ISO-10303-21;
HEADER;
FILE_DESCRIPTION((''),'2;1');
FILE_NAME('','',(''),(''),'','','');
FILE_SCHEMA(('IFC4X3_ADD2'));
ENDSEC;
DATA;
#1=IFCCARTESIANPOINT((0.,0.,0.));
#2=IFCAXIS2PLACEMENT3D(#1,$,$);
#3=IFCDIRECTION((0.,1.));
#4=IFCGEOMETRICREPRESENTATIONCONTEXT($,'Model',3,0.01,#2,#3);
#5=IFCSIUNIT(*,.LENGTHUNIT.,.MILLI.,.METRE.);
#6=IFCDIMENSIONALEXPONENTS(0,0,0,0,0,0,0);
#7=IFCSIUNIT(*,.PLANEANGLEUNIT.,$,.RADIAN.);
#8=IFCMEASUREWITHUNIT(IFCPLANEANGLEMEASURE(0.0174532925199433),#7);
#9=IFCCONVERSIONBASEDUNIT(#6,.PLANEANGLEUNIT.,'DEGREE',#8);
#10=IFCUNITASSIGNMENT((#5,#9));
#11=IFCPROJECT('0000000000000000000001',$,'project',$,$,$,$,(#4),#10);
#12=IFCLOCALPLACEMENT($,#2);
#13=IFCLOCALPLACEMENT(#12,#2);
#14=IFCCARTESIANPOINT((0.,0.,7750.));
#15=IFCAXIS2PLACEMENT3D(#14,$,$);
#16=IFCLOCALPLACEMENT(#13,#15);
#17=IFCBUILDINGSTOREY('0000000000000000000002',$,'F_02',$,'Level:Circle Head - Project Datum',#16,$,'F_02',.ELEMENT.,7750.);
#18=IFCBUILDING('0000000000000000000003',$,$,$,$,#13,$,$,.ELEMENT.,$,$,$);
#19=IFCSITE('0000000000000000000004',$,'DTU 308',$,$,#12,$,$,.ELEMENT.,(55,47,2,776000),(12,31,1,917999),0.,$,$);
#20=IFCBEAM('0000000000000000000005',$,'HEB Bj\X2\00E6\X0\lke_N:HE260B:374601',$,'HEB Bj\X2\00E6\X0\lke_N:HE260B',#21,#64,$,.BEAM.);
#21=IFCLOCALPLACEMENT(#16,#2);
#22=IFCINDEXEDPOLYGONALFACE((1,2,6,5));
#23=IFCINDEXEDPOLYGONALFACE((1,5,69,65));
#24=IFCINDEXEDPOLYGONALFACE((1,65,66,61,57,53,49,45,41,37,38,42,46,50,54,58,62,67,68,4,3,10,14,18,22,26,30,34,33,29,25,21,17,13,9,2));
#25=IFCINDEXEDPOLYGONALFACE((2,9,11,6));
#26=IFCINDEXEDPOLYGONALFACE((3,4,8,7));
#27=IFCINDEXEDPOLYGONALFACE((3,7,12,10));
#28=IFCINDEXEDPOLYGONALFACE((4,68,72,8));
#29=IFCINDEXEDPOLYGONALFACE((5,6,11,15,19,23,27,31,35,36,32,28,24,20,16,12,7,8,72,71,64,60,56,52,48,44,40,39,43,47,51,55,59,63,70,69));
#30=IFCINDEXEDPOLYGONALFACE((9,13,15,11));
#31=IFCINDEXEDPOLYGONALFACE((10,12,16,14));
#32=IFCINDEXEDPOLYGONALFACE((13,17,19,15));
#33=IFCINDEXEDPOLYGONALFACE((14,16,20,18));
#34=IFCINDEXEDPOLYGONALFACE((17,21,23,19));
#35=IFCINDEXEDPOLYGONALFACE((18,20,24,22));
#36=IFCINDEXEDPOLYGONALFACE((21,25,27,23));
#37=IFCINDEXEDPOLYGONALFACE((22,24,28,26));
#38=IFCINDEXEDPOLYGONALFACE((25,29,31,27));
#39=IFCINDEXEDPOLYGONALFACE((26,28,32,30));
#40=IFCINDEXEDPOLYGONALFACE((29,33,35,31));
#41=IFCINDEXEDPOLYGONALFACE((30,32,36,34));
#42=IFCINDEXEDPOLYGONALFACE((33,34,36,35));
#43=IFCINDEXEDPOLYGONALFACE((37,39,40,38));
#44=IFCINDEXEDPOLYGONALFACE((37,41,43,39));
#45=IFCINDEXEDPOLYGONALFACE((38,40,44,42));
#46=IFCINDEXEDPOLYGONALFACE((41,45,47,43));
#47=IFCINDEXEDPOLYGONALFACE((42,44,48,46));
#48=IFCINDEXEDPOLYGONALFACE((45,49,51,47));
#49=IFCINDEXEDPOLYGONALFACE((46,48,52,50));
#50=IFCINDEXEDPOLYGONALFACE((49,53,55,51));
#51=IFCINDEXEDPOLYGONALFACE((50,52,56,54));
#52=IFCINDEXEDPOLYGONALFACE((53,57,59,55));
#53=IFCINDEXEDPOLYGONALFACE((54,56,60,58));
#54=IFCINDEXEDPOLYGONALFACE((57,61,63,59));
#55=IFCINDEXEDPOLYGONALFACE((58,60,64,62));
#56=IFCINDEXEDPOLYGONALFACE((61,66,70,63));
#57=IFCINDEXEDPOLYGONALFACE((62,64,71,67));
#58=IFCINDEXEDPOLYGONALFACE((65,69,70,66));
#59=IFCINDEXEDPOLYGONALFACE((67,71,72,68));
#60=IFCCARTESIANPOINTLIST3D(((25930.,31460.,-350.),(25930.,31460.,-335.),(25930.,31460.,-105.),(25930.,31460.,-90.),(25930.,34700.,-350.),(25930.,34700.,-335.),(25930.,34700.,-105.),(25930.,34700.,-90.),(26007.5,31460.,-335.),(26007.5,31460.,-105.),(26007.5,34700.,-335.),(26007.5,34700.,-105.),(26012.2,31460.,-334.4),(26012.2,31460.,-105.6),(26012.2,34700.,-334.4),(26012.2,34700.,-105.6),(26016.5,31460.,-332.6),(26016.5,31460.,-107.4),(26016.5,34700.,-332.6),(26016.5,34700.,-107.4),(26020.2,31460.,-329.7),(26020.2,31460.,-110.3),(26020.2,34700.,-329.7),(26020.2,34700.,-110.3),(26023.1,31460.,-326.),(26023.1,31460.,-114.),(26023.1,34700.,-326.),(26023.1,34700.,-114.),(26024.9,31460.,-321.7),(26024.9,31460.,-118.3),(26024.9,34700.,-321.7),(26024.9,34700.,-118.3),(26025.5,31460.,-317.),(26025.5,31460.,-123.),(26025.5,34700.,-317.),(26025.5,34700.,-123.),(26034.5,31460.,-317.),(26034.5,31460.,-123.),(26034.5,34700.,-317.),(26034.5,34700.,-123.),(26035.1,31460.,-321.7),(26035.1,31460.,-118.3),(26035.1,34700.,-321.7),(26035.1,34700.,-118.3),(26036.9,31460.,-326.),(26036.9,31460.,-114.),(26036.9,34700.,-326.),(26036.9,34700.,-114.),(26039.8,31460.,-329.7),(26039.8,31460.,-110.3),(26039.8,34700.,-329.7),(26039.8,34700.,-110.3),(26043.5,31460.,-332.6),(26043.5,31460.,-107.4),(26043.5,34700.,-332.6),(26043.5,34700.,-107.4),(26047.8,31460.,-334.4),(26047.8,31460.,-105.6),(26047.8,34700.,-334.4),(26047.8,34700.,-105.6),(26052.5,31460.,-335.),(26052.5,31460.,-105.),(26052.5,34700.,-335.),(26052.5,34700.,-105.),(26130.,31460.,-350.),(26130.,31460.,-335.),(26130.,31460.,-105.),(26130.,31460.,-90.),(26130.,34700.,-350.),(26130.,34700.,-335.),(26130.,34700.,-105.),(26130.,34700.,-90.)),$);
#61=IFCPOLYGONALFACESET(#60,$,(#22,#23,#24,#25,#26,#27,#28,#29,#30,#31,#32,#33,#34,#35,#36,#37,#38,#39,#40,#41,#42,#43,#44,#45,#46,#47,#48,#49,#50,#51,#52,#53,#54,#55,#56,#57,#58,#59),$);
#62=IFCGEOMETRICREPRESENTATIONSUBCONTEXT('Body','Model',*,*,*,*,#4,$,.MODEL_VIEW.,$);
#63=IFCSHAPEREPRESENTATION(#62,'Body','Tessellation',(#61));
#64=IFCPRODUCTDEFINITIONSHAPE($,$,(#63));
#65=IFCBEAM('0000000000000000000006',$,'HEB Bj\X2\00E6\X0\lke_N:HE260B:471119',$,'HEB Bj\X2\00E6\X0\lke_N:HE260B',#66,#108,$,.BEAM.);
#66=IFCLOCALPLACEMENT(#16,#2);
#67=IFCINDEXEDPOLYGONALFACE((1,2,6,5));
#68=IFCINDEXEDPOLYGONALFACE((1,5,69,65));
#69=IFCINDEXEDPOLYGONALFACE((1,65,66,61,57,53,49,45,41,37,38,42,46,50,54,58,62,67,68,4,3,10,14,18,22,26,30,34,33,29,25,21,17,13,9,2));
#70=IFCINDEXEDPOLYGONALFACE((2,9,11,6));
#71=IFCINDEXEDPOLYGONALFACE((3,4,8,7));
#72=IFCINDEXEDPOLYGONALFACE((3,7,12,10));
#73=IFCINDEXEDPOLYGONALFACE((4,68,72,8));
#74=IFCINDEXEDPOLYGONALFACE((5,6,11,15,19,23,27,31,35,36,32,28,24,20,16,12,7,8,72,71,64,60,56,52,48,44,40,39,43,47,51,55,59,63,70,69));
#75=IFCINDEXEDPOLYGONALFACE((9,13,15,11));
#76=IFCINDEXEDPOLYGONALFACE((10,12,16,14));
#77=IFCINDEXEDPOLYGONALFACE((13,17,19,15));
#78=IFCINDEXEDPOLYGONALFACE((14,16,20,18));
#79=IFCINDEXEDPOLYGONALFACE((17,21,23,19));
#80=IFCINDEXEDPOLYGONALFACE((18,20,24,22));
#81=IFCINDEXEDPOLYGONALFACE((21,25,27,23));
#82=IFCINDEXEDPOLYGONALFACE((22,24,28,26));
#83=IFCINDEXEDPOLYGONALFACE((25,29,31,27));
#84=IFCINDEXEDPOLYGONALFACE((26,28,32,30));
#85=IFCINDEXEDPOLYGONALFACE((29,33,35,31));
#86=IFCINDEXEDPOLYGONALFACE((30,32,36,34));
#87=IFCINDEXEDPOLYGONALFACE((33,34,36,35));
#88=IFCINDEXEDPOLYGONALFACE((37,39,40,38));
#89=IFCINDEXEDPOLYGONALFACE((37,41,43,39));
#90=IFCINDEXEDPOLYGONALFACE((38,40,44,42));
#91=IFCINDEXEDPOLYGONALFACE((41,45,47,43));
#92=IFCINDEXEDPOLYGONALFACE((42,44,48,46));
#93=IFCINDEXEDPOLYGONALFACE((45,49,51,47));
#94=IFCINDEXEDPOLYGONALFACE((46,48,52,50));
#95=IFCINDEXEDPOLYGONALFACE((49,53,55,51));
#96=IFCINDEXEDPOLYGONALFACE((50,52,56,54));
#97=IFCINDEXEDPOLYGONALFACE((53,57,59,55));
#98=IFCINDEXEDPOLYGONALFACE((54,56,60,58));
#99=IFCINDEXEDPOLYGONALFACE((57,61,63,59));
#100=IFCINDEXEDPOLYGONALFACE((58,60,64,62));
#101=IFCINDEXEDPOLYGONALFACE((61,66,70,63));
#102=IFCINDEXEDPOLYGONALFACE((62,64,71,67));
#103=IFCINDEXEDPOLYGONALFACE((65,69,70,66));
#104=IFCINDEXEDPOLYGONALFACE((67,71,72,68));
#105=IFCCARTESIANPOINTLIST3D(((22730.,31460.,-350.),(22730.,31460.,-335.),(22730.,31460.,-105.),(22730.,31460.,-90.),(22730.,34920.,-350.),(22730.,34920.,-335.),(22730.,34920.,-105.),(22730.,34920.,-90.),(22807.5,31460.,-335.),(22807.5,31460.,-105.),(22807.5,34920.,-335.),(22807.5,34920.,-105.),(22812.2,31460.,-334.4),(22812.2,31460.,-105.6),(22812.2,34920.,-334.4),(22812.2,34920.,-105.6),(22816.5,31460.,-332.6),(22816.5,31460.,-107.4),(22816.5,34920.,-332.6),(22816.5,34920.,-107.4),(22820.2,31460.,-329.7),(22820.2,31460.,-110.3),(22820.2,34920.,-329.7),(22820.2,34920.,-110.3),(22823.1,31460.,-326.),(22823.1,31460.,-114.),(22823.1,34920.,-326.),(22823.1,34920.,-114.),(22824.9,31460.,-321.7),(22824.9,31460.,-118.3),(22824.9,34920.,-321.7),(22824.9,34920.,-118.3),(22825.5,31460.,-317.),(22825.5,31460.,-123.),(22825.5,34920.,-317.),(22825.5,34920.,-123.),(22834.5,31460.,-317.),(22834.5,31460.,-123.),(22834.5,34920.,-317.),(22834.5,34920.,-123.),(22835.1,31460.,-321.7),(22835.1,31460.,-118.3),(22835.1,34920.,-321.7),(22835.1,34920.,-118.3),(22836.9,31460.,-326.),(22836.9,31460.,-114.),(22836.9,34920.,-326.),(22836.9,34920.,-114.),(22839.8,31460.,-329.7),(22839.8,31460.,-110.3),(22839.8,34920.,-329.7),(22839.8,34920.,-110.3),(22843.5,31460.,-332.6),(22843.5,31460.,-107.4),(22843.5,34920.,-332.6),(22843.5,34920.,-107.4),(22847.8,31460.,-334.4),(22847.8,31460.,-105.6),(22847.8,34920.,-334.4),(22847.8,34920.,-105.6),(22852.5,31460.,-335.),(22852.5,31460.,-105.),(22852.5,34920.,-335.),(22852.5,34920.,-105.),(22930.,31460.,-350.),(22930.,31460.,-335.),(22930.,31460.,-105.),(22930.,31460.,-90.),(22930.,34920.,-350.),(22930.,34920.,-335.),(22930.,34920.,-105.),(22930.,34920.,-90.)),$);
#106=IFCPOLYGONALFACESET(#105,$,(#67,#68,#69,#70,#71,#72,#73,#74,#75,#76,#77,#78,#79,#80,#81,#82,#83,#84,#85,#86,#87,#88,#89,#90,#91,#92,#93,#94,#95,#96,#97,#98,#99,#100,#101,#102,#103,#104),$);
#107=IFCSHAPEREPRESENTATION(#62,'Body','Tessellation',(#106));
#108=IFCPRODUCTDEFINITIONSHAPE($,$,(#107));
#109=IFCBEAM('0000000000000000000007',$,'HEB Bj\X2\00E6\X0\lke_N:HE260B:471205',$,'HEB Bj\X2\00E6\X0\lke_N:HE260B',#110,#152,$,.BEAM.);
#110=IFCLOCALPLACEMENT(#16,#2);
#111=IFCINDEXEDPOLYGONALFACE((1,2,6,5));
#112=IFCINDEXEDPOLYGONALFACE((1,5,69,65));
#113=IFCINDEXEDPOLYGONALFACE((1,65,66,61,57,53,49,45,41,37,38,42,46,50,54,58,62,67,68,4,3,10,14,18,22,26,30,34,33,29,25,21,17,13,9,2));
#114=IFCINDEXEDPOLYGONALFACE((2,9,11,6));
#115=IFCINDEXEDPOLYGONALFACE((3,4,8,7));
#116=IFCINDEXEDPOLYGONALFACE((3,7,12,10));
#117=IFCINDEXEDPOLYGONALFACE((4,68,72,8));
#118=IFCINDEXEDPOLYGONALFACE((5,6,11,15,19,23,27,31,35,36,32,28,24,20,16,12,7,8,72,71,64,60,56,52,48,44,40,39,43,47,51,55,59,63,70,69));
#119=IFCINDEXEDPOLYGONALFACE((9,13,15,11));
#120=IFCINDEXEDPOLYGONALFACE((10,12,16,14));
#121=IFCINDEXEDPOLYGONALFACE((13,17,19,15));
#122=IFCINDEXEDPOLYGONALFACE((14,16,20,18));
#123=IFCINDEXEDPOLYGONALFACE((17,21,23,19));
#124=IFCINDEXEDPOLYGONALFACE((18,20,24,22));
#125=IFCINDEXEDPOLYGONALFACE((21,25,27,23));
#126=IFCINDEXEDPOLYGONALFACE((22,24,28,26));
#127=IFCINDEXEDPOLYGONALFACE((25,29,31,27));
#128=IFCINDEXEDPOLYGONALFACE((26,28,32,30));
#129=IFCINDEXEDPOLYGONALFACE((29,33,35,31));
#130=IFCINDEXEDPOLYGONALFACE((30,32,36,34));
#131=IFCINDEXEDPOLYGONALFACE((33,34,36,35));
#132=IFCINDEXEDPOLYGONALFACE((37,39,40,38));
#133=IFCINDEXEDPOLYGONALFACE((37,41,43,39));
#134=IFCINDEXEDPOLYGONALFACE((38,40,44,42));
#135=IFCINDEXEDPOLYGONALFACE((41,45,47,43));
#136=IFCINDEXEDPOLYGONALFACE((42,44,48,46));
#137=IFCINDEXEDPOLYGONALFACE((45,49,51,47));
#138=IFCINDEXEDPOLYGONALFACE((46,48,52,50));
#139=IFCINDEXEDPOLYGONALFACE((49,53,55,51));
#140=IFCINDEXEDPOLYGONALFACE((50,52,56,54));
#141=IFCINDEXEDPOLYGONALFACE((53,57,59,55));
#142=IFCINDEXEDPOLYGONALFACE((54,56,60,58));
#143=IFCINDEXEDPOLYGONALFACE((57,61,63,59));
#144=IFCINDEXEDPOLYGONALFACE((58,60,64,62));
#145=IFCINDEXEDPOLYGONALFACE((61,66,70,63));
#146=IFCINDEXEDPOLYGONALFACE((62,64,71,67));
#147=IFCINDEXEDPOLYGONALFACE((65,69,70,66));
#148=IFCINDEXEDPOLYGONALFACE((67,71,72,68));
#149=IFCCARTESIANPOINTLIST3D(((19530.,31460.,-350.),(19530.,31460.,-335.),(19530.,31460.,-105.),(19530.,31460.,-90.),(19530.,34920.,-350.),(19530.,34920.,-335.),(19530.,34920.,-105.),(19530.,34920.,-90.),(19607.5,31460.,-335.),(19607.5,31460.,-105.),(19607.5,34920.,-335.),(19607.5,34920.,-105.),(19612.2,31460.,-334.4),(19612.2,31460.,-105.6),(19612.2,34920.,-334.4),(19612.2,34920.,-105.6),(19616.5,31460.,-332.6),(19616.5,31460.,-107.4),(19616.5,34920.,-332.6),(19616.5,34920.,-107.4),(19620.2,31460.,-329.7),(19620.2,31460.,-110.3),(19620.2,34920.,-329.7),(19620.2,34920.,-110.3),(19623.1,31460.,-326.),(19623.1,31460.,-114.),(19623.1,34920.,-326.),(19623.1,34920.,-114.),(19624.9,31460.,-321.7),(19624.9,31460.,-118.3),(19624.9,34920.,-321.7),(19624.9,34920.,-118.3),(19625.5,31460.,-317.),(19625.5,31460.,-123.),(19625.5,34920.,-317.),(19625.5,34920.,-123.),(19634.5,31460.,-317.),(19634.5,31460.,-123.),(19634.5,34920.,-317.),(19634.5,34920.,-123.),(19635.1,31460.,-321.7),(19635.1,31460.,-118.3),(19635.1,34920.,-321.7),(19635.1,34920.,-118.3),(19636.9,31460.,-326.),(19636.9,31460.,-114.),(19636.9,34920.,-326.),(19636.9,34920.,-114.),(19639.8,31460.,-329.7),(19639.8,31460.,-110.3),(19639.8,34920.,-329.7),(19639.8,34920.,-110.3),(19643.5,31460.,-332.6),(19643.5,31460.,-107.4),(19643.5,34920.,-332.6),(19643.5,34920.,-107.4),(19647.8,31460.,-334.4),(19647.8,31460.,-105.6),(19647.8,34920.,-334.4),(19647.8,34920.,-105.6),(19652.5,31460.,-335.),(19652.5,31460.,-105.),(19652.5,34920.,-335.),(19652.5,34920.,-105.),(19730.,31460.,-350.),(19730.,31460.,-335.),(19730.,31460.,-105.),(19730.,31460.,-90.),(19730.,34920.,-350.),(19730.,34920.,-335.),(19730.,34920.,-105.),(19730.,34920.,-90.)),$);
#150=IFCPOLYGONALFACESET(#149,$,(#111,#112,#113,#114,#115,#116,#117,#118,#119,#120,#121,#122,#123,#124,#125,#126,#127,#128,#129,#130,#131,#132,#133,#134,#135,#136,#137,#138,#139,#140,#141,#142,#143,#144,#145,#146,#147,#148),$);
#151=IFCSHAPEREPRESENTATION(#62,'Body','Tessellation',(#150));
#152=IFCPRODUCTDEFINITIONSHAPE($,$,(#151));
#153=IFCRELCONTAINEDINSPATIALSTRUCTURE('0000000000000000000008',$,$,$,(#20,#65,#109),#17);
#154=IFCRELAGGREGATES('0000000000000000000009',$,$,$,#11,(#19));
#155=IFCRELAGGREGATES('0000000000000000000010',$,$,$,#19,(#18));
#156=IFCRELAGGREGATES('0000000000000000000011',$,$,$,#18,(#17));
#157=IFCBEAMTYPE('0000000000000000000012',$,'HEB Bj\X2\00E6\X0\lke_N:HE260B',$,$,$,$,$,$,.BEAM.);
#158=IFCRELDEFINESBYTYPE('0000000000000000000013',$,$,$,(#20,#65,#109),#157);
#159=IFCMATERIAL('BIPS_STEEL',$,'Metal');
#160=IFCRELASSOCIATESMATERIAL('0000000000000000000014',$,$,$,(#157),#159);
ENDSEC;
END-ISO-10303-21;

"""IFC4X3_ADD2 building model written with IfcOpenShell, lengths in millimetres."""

from ifc_helpers import new_model, entity, si_unit, converted_unit, direction, frame, frame_2d, origin, place, context, subcontext, project, spatial, polyline, circle_curve, parameter, trimmed, segment, composite_curve, i_section, outline, extrude, source, transform, mapped, material, material_profile, profile_set, type_object, element, save


model = new_model("IFC4X3_ADD2")

# Units and contexts
model_context = context("Model", 3, precision=0.01, world=origin(), true_north=direction((0.0, 1.0)))
body_context = subcontext(model_context, "Body", "Model", "MODEL_VIEW")
ifc_project = project(units=[si_unit("LENGTHUNIT", "METRE", prefix="MILLI"), converted_unit("PLANEANGLEUNIT", "DEGREE", entity("IfcPlaneAngleMeasure", 0.0174532925199433), si_unit("PLANEANGLEUNIT", "RADIAN"), dimensions=[0, 0, 0, 0, 0, 0, 0])], contexts=[model_context])

# Site, building, storey
site_placement = place(None, origin())
site = spatial("IfcSite", under=ifc_project, at=site_placement, Name="DTU 308", CompositionType="ELEMENT", RefLatitude=(55, 47, 2, 776000), RefLongitude=(12, 31, 1, 917999), RefElevation=0.0)
building_placement = place(site_placement, origin())
building = spatial("IfcBuilding", under=site, at=building_placement, CompositionType="ELEMENT")
storey_placement = place(building_placement, frame((0.0, 0.0, 7750.0)))
storey = spatial("IfcBuildingStorey", under=building, at=storey_placement, Name="F_02", ObjectType="Level:Circle Head - Project Datum", LongName="F_02", CompositionType="ELEMENT", Elevation=7750.0)

# Shared definitions
ifc_material = material(Name="BIPS_STEEL", Category="Metal")

# Beams
ifc_material_profile_1 = material_profile(ifc_material, i_section(OverallWidth=200.0, OverallDepth=260.0, WebThickness=9.0, FlangeThickness=15.0, FilletRadius=18.0, at=frame_2d((0.0, 0.0), x_axis=(1.0, 0.0))), Name="HE260B")
ifc_profile_set_1 = profile_set([ifc_material_profile_1], Name="HE260B")
beam_type_1 = type_object("IfcBeamType", Name="HEB Bjælke_N:HE260B", PredefinedType="BEAM", material=ifc_profile_set_1)
shared_shape_1 = source(origin(), body_context, "Body", "SweptSolid", [
    extrude(outline(composite_curve([segment(polyline([(-100.0, -115.0), (-100.0, -130.0)]), True, "CONTINUOUS"), segment(polyline([(-100.0, -130.0), (100.0, -130.0)]), True, "CONTINUOUS"), segment(polyline([(100.0, -130.0), (100.0, -115.0)]), True, "CONTINUOUS"), segment(polyline([(100.0, -115.0), (22.5, -115.0)]), True, "CONTINUOUS"), segment(trimmed(circle_curve(frame_2d((22.5, -97.0), x_axis=(1.0, 0.0)), 18.0), [parameter(180.0)], [parameter(270.0)], True, "PARAMETER"), False, "CONTINUOUS"), segment(polyline([(4.5, -97.0), (4.5, 97.0)]), True, "CONTINUOUS"), segment(trimmed(circle_curve(frame_2d((22.5, 97.0), x_axis=(1.0, 0.0)), 18.0), [parameter(90.0)], [parameter(180.0)], True, "PARAMETER"), False, "CONTINUOUS"), segment(polyline([(22.5, 115.0), (100.0, 115.0)]), True, "CONTINUOUS"), segment(polyline([(100.0, 115.0), (100.0, 130.0)]), True, "CONTINUOUS"), segment(polyline([(100.0, 130.0), (-100.0, 130.0)]), True, "CONTINUOUS"), segment(polyline([(-100.0, 130.0), (-100.0, 115.0)]), True, "CONTINUOUS"), segment(polyline([(-100.0, 115.0), (-22.5, 115.0)]), True, "CONTINUOUS"), segment(trimmed(circle_curve(frame_2d((-22.5, 97.0), x_axis=(1.0, 0.0)), 18.0), [parameter(360.0)], [parameter(90.0)], True, "PARAMETER"), False, "CONTINUOUS"), segment(polyline([(-4.5, 97.0), (-4.5, -97.0)]), True, "CONTINUOUS"), segment(trimmed(circle_curve(frame_2d((-22.5, -97.0), x_axis=(1.0, 0.0)), 18.0), [parameter(270.0)], [parameter(360.0)], True, "PARAMETER"), False, "CONTINUOUS"), segment(polyline([(-22.5, -115.0), (-100.0, -115.0)]), True, "CONTINUOUS")], self_intersect=False)), frame((-1500.0, 0.0, 0.0), z_axis=(-1.0, 0.0, 0.0), x_axis=(0.0, -1.0, 0.0)), (0.0, 0.0, -1.0), 3240.0),
])
beam_1_placement = place(storey_placement, frame((26030.0, 33200.0, -220.0), z_axis=(0.0, 0.0, 1.0), x_axis=(0.0, -1.0, 0.0)))
element("IfcBeam", 1, at=beam_1_placement, inside=storey, type_object=beam_type_1, Name="HEB Bjælke_N:HE260B:374601", ObjectType="HEB Bjælke_N:HE260B", PredefinedType="BEAM", context=body_context, shape_type="MappedRepresentation", body=[
    mapped(shared_shape_1, transform((0.0, 0.0, 0.0), scale=1.0)),
])
shared_shape_2 = source(origin(), body_context, "Body", "SweptSolid", [
    extrude(outline(composite_curve([segment(polyline([(-100.0, -115.0), (-100.0, -130.0)]), True, "CONTINUOUS"), segment(polyline([(-100.0, -130.0), (100.0, -130.0)]), True, "CONTINUOUS"), segment(polyline([(100.0, -130.0), (100.0, -115.0)]), True, "CONTINUOUS"), segment(polyline([(100.0, -115.0), (22.5, -115.0)]), True, "CONTINUOUS"), segment(trimmed(circle_curve(frame_2d((22.5, -97.0), x_axis=(1.0, 0.0)), 18.0), [parameter(180.0)], [parameter(270.0)], True, "PARAMETER"), False, "CONTINUOUS"), segment(polyline([(4.5, -97.0), (4.5, 97.0)]), True, "CONTINUOUS"), segment(trimmed(circle_curve(frame_2d((22.5, 97.0), x_axis=(1.0, 0.0)), 18.0), [parameter(90.0)], [parameter(180.0)], True, "PARAMETER"), False, "CONTINUOUS"), segment(polyline([(22.5, 115.0), (100.0, 115.0)]), True, "CONTINUOUS"), segment(polyline([(100.0, 115.0), (100.0, 130.0)]), True, "CONTINUOUS"), segment(polyline([(100.0, 130.0), (-100.0, 130.0)]), True, "CONTINUOUS"), segment(polyline([(-100.0, 130.0), (-100.0, 115.0)]), True, "CONTINUOUS"), segment(polyline([(-100.0, 115.0), (-22.5, 115.0)]), True, "CONTINUOUS"), segment(trimmed(circle_curve(frame_2d((-22.5, 97.0), x_axis=(1.0, 0.0)), 18.0), [parameter(360.0)], [parameter(90.0)], True, "PARAMETER"), False, "CONTINUOUS"), segment(polyline([(-4.5, 97.0), (-4.5, -97.0)]), True, "CONTINUOUS"), segment(trimmed(circle_curve(frame_2d((-22.5, -97.0), x_axis=(1.0, 0.0)), 18.0), [parameter(270.0)], [parameter(360.0)], True, "PARAMETER"), False, "CONTINUOUS"), segment(polyline([(-22.5, -115.0), (-100.0, -115.0)]), True, "CONTINUOUS")], self_intersect=False)), frame((-1720.0, 0.0, 0.0), z_axis=(-1.0, 0.0, 0.0), x_axis=(0.0, -1.0, 0.0)), (0.0, 0.0, -1.0), 3460.0),
])
for number, where, z_axis, x_axis, name in (
    (2, (22830.0, 33200.0, -220.0), (0.0, 0.0, 1.0), (0.0, -1.0, 0.0), "HEB Bjælke_N:HE260B:471119"),
    (3, (19630.0, 33200.0, -220.0), (0.0, 0.0, 1.0), (0.0, -1.0, 0.0), "HEB Bjælke_N:HE260B:471205"),
):
    element("IfcBeam", number, at=place(storey_placement, frame(where, z_axis=z_axis, x_axis=x_axis)), inside=storey, type_object=beam_type_1, Name=name, ObjectType="HEB Bjælke_N:HE260B", PredefinedType="BEAM", context=body_context, shape_type="MappedRepresentation", body=[
        mapped(shared_shape_2, transform((0.0, 0.0, 0.0), scale=1.0)),
    ])

save(model, "model.ifc")
